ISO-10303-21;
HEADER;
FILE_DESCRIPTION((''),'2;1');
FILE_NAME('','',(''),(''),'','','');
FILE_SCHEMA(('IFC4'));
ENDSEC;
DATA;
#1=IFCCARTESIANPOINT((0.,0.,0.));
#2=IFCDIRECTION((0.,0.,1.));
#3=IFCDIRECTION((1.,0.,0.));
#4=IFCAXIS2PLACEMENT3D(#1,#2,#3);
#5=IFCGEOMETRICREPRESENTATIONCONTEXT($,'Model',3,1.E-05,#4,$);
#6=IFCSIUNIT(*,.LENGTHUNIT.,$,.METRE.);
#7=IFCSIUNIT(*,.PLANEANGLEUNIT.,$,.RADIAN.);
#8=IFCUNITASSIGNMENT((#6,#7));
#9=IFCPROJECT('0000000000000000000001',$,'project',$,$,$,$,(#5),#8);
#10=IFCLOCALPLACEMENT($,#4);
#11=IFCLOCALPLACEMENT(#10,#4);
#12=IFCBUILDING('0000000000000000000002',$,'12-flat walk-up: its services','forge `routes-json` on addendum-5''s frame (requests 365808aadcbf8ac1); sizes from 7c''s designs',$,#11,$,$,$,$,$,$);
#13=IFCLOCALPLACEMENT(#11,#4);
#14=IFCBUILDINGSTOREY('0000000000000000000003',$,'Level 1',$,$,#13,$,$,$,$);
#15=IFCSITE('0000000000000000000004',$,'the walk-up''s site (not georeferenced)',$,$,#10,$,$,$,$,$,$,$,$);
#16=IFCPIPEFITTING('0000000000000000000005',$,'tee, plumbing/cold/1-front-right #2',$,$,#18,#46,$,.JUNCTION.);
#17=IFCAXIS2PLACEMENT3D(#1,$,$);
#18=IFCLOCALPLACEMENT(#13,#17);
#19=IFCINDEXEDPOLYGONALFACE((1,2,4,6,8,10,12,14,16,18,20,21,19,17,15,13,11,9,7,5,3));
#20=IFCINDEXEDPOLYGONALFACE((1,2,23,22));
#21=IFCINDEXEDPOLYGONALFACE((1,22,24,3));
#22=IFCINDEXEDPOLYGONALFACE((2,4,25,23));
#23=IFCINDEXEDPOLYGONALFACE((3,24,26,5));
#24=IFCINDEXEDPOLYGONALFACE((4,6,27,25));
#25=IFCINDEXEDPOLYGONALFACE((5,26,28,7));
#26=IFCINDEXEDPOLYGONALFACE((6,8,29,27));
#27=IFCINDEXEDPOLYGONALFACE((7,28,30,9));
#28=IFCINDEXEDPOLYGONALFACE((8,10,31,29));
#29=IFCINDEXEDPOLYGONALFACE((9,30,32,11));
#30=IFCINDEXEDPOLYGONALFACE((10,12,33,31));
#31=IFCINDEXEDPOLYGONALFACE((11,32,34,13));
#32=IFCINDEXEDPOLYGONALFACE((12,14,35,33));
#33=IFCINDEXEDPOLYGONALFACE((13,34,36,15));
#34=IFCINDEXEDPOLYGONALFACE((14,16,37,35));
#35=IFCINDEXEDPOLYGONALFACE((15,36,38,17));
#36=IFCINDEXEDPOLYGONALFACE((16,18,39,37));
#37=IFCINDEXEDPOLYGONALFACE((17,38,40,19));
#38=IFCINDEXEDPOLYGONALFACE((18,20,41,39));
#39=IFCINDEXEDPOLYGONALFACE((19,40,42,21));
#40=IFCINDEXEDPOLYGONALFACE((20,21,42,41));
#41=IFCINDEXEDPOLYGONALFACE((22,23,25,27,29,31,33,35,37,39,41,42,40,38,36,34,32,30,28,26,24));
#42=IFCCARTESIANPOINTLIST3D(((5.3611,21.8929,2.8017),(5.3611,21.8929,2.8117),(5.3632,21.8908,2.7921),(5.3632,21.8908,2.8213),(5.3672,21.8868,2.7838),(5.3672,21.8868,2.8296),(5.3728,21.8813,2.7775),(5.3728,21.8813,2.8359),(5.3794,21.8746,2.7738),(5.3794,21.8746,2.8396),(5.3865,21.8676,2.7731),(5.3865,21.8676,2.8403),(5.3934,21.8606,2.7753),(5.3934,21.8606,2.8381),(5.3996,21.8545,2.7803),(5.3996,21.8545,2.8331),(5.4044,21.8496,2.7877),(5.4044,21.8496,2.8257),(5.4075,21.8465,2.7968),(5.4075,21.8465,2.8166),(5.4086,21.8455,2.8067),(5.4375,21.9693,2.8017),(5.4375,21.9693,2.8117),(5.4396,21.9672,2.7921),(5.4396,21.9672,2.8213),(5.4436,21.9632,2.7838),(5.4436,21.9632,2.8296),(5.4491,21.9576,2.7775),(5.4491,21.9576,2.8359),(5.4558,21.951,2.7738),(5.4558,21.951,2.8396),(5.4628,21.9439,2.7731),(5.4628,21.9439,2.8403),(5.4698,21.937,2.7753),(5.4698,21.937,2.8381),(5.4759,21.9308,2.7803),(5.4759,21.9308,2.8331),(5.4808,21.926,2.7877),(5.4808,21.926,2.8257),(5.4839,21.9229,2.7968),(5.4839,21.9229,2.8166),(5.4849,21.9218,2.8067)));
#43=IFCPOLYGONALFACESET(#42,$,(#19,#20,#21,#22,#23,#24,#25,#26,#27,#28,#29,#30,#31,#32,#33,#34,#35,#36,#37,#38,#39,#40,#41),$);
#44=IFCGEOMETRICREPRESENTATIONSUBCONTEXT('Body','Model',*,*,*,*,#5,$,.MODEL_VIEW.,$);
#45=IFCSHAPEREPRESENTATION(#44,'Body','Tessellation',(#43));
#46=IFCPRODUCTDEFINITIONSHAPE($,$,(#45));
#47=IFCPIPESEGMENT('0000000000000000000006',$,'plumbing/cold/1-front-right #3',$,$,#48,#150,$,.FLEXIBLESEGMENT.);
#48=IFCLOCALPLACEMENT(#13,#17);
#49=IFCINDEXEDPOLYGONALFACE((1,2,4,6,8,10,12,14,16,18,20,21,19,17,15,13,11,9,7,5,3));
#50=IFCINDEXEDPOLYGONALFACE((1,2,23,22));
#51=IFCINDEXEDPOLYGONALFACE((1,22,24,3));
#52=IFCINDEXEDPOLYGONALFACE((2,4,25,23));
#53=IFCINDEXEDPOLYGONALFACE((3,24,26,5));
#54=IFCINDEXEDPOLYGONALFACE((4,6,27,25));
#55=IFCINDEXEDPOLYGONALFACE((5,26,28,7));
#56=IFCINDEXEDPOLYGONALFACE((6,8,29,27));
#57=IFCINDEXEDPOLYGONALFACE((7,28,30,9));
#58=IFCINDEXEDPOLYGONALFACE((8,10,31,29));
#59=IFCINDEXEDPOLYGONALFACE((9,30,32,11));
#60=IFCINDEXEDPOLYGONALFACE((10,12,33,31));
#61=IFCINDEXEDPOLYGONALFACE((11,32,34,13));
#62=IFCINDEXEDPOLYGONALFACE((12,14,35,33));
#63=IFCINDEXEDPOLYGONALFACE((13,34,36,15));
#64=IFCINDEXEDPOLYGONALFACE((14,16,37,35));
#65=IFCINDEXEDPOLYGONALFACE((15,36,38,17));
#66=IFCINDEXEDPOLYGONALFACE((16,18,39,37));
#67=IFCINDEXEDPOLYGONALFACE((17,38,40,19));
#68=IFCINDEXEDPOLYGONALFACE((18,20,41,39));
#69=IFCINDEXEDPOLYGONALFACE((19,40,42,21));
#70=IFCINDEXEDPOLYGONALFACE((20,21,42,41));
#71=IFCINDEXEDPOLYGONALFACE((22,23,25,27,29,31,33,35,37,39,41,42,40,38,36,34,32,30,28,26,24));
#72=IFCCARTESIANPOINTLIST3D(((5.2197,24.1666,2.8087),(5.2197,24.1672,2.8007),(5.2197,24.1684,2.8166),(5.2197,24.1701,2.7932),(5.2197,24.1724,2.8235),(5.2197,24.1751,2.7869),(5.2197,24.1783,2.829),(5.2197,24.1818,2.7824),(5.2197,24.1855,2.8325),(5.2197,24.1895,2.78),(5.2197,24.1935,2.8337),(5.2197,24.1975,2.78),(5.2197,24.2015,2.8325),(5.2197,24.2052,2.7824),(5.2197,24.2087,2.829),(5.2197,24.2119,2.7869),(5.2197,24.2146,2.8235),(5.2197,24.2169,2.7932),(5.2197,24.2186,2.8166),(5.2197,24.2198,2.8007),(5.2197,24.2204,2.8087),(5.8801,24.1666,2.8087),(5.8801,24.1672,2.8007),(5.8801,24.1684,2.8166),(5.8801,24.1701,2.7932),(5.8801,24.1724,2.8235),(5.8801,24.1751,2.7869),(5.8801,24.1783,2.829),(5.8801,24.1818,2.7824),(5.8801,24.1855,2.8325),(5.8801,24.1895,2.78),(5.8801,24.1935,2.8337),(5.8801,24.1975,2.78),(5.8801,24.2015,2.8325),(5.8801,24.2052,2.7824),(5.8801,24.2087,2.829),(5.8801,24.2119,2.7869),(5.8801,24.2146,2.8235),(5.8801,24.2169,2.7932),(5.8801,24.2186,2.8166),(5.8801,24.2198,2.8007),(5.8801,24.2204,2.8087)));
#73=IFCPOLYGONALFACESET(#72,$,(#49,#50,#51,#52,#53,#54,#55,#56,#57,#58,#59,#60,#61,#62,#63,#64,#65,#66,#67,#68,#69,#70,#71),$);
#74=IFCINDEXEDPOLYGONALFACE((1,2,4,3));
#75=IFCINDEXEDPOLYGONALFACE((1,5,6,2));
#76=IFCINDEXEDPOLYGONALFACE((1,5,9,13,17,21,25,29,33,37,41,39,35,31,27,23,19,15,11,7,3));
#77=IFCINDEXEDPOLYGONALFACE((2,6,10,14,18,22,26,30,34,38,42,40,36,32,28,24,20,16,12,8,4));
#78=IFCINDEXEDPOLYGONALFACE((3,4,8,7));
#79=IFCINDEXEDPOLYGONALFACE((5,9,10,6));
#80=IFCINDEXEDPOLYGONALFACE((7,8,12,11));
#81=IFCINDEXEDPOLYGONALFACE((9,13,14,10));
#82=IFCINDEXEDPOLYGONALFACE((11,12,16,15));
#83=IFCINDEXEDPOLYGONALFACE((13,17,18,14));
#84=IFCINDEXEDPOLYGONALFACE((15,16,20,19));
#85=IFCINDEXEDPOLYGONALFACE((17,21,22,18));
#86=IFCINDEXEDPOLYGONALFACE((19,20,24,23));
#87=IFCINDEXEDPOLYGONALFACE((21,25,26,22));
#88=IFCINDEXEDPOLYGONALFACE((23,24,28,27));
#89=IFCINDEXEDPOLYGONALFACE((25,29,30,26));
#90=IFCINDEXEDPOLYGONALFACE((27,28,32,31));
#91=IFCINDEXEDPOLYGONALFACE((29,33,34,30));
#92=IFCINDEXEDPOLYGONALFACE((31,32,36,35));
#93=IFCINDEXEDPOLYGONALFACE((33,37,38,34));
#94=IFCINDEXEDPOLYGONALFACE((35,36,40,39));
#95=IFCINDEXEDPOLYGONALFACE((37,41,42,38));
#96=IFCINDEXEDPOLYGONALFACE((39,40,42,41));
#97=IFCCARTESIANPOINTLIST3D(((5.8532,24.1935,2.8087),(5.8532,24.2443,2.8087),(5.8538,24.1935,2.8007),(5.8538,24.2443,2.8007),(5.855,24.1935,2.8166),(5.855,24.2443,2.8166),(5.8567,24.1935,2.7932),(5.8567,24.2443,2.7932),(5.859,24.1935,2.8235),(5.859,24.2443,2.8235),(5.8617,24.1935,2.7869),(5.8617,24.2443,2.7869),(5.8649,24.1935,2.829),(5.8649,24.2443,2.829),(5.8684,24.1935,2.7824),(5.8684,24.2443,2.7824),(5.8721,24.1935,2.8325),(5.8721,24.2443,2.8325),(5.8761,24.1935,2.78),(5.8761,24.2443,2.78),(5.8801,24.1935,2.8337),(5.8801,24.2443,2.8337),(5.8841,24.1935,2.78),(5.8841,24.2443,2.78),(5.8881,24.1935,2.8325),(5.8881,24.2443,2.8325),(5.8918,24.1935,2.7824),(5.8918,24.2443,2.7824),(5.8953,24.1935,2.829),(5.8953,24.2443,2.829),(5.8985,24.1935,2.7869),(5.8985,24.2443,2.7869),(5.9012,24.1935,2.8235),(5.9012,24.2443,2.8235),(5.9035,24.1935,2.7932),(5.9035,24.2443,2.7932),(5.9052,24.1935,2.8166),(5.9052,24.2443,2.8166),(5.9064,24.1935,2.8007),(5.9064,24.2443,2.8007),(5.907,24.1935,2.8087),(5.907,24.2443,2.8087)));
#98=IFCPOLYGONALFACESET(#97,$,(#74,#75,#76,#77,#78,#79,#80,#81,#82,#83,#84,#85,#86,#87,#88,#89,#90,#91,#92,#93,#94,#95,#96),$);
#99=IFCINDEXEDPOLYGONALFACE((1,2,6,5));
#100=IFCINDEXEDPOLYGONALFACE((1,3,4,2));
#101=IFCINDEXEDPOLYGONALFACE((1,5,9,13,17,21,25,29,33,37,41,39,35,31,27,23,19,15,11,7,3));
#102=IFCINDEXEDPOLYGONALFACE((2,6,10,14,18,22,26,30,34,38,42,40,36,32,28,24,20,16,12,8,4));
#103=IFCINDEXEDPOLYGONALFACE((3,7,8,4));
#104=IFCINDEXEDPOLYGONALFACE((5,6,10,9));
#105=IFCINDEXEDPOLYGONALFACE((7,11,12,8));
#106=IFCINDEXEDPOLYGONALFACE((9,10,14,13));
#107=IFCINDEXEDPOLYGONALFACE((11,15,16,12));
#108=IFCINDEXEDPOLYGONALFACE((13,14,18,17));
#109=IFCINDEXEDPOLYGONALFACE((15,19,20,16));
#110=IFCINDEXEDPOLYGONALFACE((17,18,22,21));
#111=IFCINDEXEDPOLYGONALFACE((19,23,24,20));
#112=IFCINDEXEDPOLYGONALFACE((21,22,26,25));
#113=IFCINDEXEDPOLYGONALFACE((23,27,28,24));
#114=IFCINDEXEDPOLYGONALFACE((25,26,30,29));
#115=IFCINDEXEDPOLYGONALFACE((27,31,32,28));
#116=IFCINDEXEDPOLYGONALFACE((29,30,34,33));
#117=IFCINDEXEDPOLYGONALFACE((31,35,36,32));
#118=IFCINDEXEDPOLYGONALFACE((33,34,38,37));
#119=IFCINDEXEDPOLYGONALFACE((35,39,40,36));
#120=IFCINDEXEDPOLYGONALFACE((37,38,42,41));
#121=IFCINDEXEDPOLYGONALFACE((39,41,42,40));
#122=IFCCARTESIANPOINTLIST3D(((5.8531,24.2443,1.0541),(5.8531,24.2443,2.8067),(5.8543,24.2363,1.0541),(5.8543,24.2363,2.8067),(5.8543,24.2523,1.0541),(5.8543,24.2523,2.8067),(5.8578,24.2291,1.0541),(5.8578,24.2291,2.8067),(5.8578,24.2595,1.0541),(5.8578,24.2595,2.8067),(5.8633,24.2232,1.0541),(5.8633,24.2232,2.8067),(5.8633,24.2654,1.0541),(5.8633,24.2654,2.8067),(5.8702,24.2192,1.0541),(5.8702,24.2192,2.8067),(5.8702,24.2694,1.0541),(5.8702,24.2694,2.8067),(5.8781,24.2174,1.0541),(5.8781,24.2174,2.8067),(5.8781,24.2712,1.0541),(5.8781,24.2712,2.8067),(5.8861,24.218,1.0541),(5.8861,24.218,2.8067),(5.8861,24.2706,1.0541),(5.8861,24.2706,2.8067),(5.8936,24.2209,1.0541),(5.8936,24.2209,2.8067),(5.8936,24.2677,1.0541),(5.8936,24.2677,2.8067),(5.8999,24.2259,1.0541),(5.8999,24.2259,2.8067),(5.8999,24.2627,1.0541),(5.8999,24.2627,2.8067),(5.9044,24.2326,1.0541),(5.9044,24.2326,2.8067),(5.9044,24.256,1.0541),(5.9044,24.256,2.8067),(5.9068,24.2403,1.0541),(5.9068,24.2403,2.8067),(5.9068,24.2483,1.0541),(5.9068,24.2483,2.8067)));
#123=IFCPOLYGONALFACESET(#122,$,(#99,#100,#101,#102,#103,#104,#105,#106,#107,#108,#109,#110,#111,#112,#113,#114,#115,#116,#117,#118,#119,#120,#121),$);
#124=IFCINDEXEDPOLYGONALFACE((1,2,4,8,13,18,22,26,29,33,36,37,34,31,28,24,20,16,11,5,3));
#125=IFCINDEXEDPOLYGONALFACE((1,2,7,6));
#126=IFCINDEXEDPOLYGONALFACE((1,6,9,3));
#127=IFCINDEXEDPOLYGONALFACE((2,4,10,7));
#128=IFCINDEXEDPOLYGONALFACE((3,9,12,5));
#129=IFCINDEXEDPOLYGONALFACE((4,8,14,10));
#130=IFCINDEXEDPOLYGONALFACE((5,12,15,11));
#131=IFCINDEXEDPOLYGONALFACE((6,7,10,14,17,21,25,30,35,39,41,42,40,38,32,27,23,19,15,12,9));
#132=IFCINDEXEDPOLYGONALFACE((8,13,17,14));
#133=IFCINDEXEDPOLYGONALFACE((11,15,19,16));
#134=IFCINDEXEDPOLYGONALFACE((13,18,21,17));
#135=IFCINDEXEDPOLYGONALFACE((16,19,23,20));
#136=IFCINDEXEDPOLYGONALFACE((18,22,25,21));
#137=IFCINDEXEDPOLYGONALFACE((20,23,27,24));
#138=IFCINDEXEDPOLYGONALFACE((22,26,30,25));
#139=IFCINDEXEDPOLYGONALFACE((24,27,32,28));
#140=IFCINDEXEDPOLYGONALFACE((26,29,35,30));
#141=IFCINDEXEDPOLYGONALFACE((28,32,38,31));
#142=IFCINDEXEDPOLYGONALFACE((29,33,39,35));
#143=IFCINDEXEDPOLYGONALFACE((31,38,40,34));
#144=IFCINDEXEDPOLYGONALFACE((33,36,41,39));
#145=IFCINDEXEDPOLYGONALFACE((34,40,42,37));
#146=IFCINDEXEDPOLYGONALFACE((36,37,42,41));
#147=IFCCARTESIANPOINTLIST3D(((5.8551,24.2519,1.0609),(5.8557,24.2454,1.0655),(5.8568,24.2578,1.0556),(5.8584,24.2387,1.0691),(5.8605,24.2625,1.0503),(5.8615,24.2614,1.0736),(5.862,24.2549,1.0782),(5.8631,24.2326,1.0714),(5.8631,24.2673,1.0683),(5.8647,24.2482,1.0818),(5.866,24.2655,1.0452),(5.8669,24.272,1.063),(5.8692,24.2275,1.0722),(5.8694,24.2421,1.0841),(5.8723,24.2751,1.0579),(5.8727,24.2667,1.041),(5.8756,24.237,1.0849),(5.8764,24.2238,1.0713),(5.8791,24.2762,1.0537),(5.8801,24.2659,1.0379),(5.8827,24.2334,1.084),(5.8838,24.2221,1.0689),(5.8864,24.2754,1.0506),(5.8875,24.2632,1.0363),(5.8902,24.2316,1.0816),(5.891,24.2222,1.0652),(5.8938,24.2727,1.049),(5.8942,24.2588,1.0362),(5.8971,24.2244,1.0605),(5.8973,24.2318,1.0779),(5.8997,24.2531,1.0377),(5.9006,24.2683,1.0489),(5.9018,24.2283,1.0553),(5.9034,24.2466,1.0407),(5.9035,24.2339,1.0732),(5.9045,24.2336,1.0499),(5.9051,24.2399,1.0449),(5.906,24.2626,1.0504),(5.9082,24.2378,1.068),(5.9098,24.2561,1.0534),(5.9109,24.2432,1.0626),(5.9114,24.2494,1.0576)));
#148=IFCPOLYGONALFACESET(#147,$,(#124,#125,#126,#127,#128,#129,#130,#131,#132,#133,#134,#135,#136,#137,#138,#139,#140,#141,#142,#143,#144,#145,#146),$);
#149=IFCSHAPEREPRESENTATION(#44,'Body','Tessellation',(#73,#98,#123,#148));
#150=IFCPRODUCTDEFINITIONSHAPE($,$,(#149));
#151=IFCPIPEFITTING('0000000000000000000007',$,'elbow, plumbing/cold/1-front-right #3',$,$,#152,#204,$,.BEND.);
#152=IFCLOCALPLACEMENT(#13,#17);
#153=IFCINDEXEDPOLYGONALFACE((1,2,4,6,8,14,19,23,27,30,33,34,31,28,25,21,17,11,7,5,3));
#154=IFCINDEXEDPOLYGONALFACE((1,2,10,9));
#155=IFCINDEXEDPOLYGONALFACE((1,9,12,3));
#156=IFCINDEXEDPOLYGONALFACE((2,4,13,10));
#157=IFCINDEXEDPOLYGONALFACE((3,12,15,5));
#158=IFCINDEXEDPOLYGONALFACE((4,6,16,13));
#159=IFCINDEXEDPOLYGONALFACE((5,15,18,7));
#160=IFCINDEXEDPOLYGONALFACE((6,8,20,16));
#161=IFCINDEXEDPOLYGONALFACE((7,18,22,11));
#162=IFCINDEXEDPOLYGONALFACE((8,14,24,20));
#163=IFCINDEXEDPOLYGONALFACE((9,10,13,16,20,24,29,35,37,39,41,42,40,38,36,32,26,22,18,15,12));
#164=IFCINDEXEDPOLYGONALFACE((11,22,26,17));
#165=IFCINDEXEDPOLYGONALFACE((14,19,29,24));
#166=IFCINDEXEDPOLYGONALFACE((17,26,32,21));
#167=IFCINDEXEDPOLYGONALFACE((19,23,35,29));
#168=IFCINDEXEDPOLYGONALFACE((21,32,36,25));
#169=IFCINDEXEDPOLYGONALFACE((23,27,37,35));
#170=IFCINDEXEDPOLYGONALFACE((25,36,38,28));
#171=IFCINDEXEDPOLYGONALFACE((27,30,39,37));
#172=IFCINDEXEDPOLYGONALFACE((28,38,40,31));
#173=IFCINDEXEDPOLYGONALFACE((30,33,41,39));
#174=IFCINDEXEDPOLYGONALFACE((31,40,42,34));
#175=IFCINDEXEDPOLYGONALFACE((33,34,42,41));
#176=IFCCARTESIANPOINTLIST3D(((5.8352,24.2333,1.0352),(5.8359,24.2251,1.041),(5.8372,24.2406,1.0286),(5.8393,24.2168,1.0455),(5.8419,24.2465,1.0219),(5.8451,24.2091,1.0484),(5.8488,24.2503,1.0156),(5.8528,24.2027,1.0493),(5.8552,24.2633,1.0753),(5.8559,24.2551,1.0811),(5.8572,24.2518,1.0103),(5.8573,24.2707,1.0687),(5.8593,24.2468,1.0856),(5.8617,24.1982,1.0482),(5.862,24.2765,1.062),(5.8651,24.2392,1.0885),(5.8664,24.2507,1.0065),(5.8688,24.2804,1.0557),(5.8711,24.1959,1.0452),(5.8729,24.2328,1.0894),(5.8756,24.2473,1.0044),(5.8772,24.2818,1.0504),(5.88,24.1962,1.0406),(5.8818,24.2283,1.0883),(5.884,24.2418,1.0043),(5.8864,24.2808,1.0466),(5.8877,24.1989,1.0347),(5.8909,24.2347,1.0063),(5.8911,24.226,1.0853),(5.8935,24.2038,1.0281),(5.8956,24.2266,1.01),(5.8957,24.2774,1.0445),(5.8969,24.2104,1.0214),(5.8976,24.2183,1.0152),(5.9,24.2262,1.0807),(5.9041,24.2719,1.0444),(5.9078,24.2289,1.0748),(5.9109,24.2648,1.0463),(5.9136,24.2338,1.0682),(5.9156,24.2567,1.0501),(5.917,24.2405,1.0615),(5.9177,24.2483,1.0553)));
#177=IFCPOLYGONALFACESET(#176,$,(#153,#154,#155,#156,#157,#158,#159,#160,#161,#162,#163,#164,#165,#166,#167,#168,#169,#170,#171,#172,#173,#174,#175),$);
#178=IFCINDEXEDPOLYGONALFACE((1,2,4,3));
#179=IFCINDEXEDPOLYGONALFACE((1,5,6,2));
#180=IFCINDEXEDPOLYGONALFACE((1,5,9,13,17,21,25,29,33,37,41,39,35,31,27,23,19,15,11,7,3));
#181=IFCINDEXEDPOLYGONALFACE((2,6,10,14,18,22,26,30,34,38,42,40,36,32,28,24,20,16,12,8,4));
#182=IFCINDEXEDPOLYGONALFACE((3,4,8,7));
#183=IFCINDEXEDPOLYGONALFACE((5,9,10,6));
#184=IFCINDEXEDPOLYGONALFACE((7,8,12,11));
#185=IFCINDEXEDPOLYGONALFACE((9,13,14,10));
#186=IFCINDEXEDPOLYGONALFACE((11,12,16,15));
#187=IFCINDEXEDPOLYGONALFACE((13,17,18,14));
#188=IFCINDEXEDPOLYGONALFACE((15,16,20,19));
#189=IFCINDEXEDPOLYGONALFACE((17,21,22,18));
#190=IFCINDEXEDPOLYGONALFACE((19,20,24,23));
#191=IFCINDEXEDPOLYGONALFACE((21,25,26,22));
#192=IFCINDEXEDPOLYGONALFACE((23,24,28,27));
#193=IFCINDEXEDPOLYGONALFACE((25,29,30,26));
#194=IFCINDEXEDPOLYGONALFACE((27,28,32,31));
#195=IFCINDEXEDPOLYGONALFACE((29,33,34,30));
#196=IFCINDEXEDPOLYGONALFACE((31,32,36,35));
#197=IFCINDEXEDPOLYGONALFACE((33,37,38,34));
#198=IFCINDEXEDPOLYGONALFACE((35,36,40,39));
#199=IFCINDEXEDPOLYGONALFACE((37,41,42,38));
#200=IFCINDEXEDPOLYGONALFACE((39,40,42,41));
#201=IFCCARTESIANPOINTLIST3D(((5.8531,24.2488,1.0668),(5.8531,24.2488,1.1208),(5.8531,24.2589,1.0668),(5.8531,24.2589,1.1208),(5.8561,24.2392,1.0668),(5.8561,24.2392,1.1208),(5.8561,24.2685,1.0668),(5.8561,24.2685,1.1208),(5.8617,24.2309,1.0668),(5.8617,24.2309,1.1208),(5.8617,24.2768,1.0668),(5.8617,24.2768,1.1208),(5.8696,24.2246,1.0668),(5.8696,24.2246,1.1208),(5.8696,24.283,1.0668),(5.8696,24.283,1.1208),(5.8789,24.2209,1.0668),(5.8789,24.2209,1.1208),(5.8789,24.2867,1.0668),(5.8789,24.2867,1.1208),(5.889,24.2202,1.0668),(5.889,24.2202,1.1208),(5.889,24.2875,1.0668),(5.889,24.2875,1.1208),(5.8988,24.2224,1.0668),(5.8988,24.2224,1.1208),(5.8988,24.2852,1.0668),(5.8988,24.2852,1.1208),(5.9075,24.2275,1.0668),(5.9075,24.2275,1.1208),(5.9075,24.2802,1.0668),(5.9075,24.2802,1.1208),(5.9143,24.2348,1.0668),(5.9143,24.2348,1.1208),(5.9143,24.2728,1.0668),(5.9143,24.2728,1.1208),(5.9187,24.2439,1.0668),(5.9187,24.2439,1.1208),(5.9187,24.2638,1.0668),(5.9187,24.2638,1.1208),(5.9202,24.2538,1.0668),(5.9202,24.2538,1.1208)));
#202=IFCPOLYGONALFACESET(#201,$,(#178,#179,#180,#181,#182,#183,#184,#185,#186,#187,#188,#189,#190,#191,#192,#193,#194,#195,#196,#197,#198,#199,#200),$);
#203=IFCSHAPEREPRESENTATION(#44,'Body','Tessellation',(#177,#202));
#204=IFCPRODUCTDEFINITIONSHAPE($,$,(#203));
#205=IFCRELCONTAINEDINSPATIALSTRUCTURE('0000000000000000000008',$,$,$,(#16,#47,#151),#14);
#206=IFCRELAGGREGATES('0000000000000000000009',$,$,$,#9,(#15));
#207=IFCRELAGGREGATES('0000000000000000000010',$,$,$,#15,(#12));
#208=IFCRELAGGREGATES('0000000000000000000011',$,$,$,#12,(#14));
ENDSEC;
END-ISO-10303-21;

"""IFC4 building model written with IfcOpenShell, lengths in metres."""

from ifc_helpers import new_model, entity, si_unit, frame, origin_with_axes, place, context, subcontext, project, spatial, element, save


model = new_model("IFC4")

# Units and contexts
model_context = context("Model", 3, precision=1e-05, world=origin_with_axes())
body_context = subcontext(model_context, "Body", "Model", "MODEL_VIEW")
ifc_project = project(units=[si_unit("LENGTHUNIT", "METRE"), si_unit("PLANEANGLEUNIT", "RADIAN")], contexts=[model_context])

# Site, building, storey
site_placement = place(None, origin_with_axes())
site = spatial("IfcSite", under=ifc_project, at=site_placement, Name="the walk-up's site (not georeferenced)")
building_placement = place(site_placement, origin_with_axes())
building = spatial("IfcBuilding", under=site, at=building_placement, Name="12-flat walk-up: its services", Description="forge `routes-json` on addendum-5's frame (requests 365808aadcbf8ac1); sizes from 7c's designs")
storey_placement = place(building_placement, origin_with_axes())
storey = spatial("IfcBuildingStorey", under=building, at=storey_placement, Name="Level 1")

# Pipe fitting
pipe_fitting_1_placement = place(storey_placement, frame((5.3847, 21.8693, 2.8067), z_axis=(0.0, 0.0, 1.0), x_axis=(1.0, 0.0, 0.0)))
element("IfcPipeFitting", 1, at=pipe_fitting_1_placement, inside=storey, Name="tee, plumbing/cold/1-front-right #2", PredefinedType="JUNCTION", context=body_context, shape_type="AdvancedSweptSolid", body=[
    entity("IfcSweptDiskSolid", entity("IfcPolyline", [entity("IfcCartesianPoint", [0.0, 0.0, 0.0]), entity("IfcCartesianPoint", [0.0763, 0.0763, 0.0])]), 0.0337),
])

# Pipe segment
pipe_segment_1_placement = place(storey_placement, frame((5.2197, 24.1935, 2.8067), z_axis=(0.0, 0.0, 1.0), x_axis=(1.0, 0.0, 0.0)))
element("IfcPipeSegment", 2, at=pipe_segment_1_placement, inside=storey, Name="plumbing/cold/1-front-right #3", PredefinedType="FLEXIBLESEGMENT", context=body_context, shape_type="AdvancedSweptSolid", body=[
    entity("IfcSweptDiskSolid", entity("IfcPolyline", [entity("IfcCartesianPoint", [0.0, 0.0, 0.0]), entity("IfcCartesianPoint", [0.6604, 0.0, 0.0])]), 0.027),
    entity("IfcSweptDiskSolid", entity("IfcPolyline", [entity("IfcCartesianPoint", [0.6604, 0.0, 0.0]), entity("IfcCartesianPoint", [0.6604, 0.0508, 0.0])]), 0.027),
    entity("IfcSweptDiskSolid", entity("IfcPolyline", [entity("IfcCartesianPoint", [0.6604, 0.0508, 0.0]), entity("IfcCartesianPoint", [0.6604, 0.0508, -1.7526])]), 0.027),
    entity("IfcSweptDiskSolid", entity("IfcPolyline", [entity("IfcCartesianPoint", [0.6604, 0.0508, -1.7526]), entity("IfcCartesianPoint", [0.6668, 0.0603, -1.7399])]), 0.027),
])

# Pipe fitting
pipe_fitting_2_placement = place(storey_placement, frame((5.8664, 24.2238, 1.0267), z_axis=(0.0, 0.0, 1.0), x_axis=(1.0, 0.0, 0.0)))
element("IfcPipeFitting", 3, at=pipe_fitting_2_placement, inside=storey, Name="elbow, plumbing/cold/1-front-right #3", PredefinedType="BEND", context=body_context, shape_type="AdvancedSweptSolid", body=[
    entity("IfcSweptDiskSolid", entity("IfcPolyline", [entity("IfcCartesianPoint", [0.0, 0.0, 0.0]), entity("IfcCartesianPoint", [0.02, 0.0301, 0.0401])]), 0.0337),
    entity("IfcSweptDiskSolid", entity("IfcPolyline", [entity("IfcCartesianPoint", [0.02, 0.0301, 0.0401]), entity("IfcCartesianPoint", [0.02, 0.0301, 0.0941])]), 0.0337),
])

save(model, "model.ifc")
